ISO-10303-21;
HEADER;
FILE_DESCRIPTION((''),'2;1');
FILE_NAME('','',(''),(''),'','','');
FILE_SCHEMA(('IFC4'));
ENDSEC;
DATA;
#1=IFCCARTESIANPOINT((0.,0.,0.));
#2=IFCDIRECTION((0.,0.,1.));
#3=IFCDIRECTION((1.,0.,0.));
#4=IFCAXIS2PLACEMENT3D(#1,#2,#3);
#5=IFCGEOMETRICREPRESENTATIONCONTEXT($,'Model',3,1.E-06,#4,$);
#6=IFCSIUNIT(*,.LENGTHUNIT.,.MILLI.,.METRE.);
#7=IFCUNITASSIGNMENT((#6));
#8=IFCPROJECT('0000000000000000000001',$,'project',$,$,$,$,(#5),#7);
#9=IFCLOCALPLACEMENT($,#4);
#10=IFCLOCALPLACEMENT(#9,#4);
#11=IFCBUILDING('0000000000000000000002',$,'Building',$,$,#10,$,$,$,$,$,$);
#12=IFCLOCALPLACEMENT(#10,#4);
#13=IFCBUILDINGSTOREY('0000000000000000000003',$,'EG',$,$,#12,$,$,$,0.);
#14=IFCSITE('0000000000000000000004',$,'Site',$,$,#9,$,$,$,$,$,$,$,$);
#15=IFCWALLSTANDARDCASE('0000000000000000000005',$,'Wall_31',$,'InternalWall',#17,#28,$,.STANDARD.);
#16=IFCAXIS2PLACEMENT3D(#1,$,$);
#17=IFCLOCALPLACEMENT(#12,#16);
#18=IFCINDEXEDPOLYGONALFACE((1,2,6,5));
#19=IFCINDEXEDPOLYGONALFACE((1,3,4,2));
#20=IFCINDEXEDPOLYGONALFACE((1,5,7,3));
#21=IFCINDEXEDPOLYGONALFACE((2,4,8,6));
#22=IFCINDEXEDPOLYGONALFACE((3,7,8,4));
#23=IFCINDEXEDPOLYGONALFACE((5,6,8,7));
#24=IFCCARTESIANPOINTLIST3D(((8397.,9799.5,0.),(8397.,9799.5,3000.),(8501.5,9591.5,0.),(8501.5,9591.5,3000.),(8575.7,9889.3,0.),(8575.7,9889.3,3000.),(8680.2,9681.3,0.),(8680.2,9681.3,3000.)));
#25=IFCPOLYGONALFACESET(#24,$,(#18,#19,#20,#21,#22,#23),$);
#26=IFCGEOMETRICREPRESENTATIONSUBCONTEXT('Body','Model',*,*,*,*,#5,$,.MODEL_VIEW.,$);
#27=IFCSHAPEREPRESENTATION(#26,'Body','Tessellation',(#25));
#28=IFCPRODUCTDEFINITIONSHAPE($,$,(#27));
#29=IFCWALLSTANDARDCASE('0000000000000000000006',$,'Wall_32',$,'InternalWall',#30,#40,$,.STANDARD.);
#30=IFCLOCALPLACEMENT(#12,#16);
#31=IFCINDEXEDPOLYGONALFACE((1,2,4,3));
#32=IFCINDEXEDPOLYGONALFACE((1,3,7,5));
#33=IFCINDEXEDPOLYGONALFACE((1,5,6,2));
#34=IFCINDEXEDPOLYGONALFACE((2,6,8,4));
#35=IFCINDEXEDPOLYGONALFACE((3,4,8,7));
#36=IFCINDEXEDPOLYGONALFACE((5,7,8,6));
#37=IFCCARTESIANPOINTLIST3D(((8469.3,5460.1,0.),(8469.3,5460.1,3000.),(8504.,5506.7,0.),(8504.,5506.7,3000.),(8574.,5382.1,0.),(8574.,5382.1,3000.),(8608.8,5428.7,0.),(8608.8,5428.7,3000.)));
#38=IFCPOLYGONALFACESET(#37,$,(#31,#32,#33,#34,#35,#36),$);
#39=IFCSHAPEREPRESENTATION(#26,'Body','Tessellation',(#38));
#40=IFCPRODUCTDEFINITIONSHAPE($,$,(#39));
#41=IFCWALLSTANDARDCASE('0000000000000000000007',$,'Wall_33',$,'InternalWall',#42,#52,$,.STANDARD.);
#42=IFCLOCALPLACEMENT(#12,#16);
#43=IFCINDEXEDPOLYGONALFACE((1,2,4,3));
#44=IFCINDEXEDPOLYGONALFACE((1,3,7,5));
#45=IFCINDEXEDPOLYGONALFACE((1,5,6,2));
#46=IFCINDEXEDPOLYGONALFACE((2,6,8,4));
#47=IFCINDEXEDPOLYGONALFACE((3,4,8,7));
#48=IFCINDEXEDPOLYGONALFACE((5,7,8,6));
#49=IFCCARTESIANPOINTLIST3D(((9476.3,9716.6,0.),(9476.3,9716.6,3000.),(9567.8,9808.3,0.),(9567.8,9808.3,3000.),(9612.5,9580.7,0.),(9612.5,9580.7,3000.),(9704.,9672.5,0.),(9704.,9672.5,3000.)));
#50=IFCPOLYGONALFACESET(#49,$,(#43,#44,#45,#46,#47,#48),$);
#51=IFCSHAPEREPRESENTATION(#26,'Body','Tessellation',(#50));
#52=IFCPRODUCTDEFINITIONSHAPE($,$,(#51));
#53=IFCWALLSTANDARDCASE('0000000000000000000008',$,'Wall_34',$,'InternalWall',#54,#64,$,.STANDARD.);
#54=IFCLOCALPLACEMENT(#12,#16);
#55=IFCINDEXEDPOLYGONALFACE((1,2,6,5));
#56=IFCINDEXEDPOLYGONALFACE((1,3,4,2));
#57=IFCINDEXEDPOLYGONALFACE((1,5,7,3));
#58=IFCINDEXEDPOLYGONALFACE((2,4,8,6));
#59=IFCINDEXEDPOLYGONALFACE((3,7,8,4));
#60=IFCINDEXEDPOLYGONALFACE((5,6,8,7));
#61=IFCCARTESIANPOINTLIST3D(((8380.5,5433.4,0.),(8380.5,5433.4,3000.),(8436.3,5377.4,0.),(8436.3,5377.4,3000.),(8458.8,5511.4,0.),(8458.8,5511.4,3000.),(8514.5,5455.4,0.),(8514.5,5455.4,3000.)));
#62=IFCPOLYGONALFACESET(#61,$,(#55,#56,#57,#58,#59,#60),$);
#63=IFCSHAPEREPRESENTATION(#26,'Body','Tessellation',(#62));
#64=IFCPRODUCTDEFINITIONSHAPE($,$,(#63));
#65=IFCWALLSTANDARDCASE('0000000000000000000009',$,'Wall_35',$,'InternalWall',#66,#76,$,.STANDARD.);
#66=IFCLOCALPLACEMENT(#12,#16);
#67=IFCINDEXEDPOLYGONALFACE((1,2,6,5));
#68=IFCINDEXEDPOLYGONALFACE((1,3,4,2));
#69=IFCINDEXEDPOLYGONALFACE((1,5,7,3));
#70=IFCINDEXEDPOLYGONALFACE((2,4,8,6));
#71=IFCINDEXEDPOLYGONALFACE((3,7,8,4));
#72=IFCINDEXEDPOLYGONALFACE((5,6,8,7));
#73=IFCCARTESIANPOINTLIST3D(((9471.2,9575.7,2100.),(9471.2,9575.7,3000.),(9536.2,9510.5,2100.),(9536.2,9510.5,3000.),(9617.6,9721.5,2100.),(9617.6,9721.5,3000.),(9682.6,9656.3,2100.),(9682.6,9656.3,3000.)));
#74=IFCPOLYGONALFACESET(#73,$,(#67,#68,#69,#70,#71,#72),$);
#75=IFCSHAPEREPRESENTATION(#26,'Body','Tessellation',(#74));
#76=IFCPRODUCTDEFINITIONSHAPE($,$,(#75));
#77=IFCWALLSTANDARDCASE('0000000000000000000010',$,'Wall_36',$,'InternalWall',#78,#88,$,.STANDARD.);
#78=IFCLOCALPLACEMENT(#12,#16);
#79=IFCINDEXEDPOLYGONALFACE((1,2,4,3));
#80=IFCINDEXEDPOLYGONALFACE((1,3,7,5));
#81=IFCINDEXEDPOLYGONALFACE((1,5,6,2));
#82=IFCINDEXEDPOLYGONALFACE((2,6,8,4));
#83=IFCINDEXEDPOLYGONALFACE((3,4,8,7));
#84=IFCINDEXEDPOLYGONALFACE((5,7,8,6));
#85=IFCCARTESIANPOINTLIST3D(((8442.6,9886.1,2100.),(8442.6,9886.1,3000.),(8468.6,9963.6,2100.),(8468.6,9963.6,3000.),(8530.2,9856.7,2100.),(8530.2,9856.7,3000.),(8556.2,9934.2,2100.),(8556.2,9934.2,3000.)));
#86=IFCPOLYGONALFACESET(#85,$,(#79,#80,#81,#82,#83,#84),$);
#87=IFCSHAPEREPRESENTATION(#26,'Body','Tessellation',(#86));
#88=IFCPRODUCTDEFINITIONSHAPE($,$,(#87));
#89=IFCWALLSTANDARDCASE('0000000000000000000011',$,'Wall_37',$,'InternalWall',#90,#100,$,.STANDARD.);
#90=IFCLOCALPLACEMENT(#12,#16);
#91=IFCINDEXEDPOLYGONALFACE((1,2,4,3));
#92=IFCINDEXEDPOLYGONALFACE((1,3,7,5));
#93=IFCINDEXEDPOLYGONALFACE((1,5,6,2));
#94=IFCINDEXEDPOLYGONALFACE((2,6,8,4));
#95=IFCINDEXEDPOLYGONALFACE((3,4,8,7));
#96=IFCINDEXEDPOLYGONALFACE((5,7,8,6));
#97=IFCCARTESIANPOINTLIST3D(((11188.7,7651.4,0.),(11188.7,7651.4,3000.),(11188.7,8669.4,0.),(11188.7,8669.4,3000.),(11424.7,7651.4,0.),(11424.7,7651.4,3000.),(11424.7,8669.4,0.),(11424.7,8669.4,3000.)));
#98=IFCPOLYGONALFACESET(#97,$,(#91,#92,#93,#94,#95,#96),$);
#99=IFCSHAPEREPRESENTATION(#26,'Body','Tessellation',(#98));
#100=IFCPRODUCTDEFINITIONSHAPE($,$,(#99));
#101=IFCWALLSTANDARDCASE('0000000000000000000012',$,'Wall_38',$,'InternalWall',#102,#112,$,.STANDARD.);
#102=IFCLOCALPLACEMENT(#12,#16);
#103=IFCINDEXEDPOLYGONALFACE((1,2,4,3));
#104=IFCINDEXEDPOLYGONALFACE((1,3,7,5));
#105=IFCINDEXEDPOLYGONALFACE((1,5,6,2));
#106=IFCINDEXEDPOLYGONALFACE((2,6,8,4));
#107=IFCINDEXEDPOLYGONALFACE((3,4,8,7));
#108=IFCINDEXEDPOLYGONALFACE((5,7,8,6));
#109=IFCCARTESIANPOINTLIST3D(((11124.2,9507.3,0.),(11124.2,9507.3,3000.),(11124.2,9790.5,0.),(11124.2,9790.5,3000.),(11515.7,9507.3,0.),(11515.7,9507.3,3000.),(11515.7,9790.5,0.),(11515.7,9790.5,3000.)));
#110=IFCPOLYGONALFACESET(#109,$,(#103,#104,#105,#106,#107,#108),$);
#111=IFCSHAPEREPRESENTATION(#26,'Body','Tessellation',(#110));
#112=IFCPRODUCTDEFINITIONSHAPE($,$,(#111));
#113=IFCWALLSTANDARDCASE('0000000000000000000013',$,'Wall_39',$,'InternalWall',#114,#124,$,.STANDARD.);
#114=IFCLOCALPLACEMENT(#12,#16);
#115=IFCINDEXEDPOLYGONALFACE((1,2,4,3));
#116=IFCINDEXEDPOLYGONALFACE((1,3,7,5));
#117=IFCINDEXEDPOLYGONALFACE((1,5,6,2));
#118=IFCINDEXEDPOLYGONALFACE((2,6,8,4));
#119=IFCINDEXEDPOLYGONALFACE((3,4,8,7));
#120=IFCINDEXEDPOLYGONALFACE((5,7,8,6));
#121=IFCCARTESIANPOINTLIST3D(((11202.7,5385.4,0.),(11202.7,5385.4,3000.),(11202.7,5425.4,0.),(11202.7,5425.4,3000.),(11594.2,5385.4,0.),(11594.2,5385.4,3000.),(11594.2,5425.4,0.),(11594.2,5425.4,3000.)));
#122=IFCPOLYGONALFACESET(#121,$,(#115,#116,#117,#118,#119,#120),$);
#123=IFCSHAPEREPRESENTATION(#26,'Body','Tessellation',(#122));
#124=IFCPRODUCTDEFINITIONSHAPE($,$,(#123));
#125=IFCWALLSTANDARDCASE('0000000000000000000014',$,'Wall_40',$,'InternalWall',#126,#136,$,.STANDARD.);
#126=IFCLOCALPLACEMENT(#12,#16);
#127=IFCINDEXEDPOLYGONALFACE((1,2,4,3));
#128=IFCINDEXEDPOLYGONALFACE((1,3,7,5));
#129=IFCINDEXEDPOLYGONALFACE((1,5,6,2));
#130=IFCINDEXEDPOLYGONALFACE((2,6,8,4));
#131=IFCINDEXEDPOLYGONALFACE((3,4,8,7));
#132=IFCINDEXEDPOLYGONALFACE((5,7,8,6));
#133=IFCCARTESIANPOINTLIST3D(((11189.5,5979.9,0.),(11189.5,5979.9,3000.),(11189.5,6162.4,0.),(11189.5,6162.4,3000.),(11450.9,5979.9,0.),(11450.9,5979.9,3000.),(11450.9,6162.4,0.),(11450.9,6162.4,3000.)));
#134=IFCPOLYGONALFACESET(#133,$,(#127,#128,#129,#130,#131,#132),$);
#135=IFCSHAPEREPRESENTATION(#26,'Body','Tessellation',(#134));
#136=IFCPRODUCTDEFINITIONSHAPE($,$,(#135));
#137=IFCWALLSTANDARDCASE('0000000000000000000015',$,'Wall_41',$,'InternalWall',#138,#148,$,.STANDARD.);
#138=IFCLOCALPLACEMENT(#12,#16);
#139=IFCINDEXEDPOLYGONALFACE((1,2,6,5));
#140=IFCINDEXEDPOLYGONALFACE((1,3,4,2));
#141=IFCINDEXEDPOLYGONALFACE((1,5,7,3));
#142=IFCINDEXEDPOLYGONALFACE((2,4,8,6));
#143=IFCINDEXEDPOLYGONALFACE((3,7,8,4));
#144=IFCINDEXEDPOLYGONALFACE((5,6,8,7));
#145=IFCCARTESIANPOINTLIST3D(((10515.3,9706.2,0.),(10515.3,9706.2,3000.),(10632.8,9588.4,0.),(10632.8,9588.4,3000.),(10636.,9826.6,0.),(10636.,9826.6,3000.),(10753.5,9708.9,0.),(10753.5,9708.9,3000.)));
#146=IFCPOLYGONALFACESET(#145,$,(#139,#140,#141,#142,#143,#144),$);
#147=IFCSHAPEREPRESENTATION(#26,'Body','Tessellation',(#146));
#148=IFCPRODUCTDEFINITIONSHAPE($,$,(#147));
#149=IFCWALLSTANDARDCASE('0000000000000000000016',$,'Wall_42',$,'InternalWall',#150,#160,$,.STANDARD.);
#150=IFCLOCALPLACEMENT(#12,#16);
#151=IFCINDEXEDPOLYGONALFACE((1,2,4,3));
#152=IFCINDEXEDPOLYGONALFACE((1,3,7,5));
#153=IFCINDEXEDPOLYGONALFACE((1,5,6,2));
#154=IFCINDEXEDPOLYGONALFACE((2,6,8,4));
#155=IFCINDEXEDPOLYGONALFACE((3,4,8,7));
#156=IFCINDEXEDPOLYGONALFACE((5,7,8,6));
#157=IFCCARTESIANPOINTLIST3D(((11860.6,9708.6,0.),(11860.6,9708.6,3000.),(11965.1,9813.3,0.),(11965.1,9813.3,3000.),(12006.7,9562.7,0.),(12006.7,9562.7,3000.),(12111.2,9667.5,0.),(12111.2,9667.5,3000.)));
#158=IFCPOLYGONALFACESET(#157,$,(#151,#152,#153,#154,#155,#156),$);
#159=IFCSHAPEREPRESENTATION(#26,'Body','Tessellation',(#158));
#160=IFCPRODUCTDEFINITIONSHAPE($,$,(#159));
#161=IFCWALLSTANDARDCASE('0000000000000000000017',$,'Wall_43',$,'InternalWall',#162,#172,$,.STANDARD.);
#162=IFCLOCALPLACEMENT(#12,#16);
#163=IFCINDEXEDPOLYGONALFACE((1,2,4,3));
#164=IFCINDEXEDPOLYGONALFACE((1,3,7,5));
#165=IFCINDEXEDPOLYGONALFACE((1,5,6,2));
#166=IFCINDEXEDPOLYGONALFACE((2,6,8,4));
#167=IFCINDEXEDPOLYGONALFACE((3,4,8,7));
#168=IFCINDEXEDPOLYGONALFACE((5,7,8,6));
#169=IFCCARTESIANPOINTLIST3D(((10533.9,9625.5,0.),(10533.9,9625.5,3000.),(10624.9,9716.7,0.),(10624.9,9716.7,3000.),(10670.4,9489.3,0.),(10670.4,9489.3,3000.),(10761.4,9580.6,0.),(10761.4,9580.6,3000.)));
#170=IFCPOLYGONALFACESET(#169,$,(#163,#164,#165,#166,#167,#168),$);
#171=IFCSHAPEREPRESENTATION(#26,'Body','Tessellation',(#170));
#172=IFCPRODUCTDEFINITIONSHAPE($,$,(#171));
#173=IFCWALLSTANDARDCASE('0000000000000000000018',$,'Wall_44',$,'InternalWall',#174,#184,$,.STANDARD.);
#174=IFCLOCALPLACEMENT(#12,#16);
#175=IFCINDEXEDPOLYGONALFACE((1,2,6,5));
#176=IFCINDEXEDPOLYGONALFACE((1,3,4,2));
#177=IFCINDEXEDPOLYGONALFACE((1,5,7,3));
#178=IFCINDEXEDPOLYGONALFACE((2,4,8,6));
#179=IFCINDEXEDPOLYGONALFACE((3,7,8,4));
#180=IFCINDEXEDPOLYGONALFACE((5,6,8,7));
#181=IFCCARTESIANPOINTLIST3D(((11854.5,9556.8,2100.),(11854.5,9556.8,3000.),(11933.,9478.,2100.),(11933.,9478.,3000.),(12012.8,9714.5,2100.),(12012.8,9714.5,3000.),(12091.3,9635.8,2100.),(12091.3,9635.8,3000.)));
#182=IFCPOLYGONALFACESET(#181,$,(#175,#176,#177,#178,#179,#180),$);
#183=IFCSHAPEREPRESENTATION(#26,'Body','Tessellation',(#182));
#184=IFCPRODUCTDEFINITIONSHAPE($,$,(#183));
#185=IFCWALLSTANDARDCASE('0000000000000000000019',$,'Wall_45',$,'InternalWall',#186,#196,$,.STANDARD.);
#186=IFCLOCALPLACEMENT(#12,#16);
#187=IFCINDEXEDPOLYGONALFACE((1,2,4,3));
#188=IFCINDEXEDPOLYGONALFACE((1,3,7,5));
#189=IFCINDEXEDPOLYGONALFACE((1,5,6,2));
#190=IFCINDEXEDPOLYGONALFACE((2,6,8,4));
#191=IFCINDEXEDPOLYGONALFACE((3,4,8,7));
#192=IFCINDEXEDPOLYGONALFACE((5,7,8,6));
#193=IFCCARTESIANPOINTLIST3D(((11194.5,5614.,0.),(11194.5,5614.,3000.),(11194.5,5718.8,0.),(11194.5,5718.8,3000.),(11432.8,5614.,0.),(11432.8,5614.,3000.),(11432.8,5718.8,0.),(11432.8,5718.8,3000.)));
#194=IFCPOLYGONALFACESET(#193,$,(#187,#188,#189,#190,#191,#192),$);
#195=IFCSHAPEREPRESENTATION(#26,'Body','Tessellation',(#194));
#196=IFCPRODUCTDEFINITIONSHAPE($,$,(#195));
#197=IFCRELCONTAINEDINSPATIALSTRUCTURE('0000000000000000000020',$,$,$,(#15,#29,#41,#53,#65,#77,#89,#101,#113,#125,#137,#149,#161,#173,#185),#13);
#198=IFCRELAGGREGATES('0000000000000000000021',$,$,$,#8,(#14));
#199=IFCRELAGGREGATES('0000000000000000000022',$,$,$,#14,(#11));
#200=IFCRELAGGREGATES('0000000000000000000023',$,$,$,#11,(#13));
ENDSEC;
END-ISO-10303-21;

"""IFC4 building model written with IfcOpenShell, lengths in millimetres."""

from ifc_helpers import new_model, si_unit, frame, origin_with_axes, place, context, subcontext, project, spatial, rectangle, extrude, element, save


model = new_model("IFC4")

# Units and contexts
model_context = context("Model", 3, precision=1e-06, world=origin_with_axes())
body_context = subcontext(model_context, "Body", "Model", "MODEL_VIEW")
ifc_project = project(units=[si_unit("LENGTHUNIT", "METRE", prefix="MILLI")], contexts=[model_context])

# Site, building, storey
site_placement = place(None, origin_with_axes())
site = spatial("IfcSite", under=ifc_project, at=site_placement, Name="Site")
building_placement = place(site_placement, origin_with_axes())
building = spatial("IfcBuilding", under=site, at=building_placement, Name="Building")
storey_placement = place(building_placement, origin_with_axes())
storey = spatial("IfcBuildingStorey", under=building, at=storey_placement, Name="EG", Elevation=0.0)

# Walls
wall_1_placement = place(storey_placement, origin_with_axes())
element("IfcWallStandardCase", 1, at=wall_1_placement, inside=storey, Name="Wall_31", ObjectType="InternalWall", PredefinedType="STANDARD", context=body_context, shape_type="SweptSolid", body=[
    extrude(rectangle(XDim=232.8, YDim=200.0), frame((8538.6, 9740.4, 0.0), z_axis=(0.0, 0.0, 1.0), x_axis=(-0.448931, 0.893566, 0.0)), (0.0, 0.0, 1.0), 3000.0),
])
wall_2_placement = place(storey_placement, origin_with_axes())
element("IfcWallStandardCase", 2, at=wall_2_placement, inside=storey, Name="Wall_32", ObjectType="InternalWall", PredefinedType="STANDARD", context=body_context, shape_type="SweptSolid", body=[
    extrude(rectangle(XDim=130.6, YDim=58.2), frame((8539.0, 5444.4, 0.0), z_axis=(0.0, 0.0, 1.0), x_axis=(0.802063, -0.59724, 0.0)), (0.0, 0.0, 1.0), 3000.0),
])
wall_3_placement = place(storey_placement, origin_with_axes())
element("IfcWallStandardCase", 3, at=wall_3_placement, inside=storey, Name="Wall_33", ObjectType="InternalWall", PredefinedType="STANDARD", context=body_context, shape_type="SweptSolid", body=[
    extrude(rectangle(XDim=129.6, YDim=192.4), frame((9590.1, 9694.5, 0.0), z_axis=(0.0, 0.0, 1.0), x_axis=(0.706141, 0.708071, 0.0)), (0.0, 0.0, 1.0), 3000.0),
])
wall_4_placement = place(storey_placement, origin_with_axes())
element("IfcWallStandardCase", 4, at=wall_4_placement, inside=storey, Name="Wall_34", ObjectType="InternalWall", PredefinedType="STANDARD", context=body_context, shape_type="SweptSolid", body=[
    extrude(rectangle(XDim=110.5, YDim=79.0), frame((8447.5, 5444.4, 0.0), z_axis=(0.0, 0.0, 1.0), x_axis=(-0.708237, -0.705975, 0.0)), (0.0, 0.0, 1.0), 3000.0),
])

# Walls, openings
wall_5_placement = place(storey_placement, origin_with_axes())
wall_5 = element("IfcWallStandardCase", 5, at=wall_5_placement, inside=storey, Name="Wall_35", ObjectType="InternalWall", PredefinedType="STANDARD", context=body_context, shape_type="SweptSolid", body=[
    extrude(rectangle(XDim=92.1, YDim=206.6), frame((9576.9, 9616.0, 0.0), z_axis=(0.0, 0.0, 1.0), x_axis=(0.705748, -0.708463, 0.0)), (0.0, 0.0, 1.0), 3000.0),
])
opening_1_placement = place(wall_5_placement, origin_with_axes())
element("IfcOpeningElement", 6, at=opening_1_placement, inside=storey, cuts=wall_5, context=body_context, shape_type="SweptSolid", body=[
    extrude(rectangle(XDim=450.0, YDim=206.6), frame((9576.9, 9616.0, 0.0), z_axis=(0.0, 0.0, 1.0), x_axis=(0.705748, -0.708463, 0.0)), (0.0, 0.0, 1.0), 2100.0),
])
wall_6_placement = place(storey_placement, origin_with_axes())
wall_6 = element("IfcWallStandardCase", 7, at=wall_6_placement, inside=storey, Name="Wall_36", ObjectType="InternalWall", PredefinedType="STANDARD", context=body_context, shape_type="SweptSolid", body=[
    extrude(rectangle(XDim=81.7, YDim=92.5), frame((8499.4, 9910.1, 0.0), z_axis=(0.0, 0.0, 1.0), x_axis=(0.318062, 0.94807, 0.0)), (0.0, 0.0, 1.0), 3000.0),
])
opening_2_placement = place(wall_6_placement, origin_with_axes())
element("IfcOpeningElement", 8, at=opening_2_placement, inside=storey, cuts=wall_6, context=body_context, shape_type="SweptSolid", body=[
    extrude(rectangle(XDim=450.0, YDim=92.5), frame((8499.4, 9910.1, 0.0), z_axis=(0.0, 0.0, 1.0), x_axis=(0.318062, 0.94807, 0.0)), (0.0, 0.0, 1.0), 2100.0),
])

# Walls
wall_7_placement = place(storey_placement, origin_with_axes())
element("IfcWallStandardCase", 9, at=wall_7_placement, inside=storey, Name="Wall_37", ObjectType="InternalWall", PredefinedType="STANDARD", context=body_context, shape_type="SweptSolid", body=[
    extrude(rectangle(XDim=1018.0, YDim=236.0), frame((11306.7, 8160.4, 0.0), z_axis=(0.0, 0.0, 1.0), x_axis=(0.0, 1.0, 0.0)), (0.0, 0.0, 1.0), 3000.0),
])
wall_8_placement = place(storey_placement, origin_with_axes())
element("IfcWallStandardCase", 10, at=wall_8_placement, inside=storey, Name="Wall_38", ObjectType="InternalWall", PredefinedType="STANDARD", context=body_context, shape_type="SweptSolid", body=[
    extrude(rectangle(XDim=391.5, YDim=283.2), frame((11319.9, 9648.9, 0.0), z_axis=(0.0, 0.0, 1.0), x_axis=(1.0, 0.0, 0.0)), (0.0, 0.0, 1.0), 3000.0),
])
wall_9_placement = place(storey_placement, origin_with_axes())
element("IfcWallStandardCase", 11, at=wall_9_placement, inside=storey, Name="Wall_39", ObjectType="InternalWall", PredefinedType="STANDARD", context=body_context, shape_type="SweptSolid", body=[
    extrude(rectangle(XDim=391.5, YDim=40.0), frame((11398.4, 5405.4, 0.0), z_axis=(0.0, 0.0, 1.0), x_axis=(-1.0, 0.0, 0.0)), (0.0, 0.0, 1.0), 3000.0),
])
wall_10_placement = place(storey_placement, origin_with_axes())
element("IfcWallStandardCase", 12, at=wall_10_placement, inside=storey, Name="Wall_40", ObjectType="InternalWall", PredefinedType="STANDARD", context=body_context, shape_type="SweptSolid", body=[
    extrude(rectangle(XDim=182.5, YDim=261.4), frame((11320.2, 6071.1, 0.0), z_axis=(0.0, 0.0, 1.0), x_axis=(0.0, 1.0, 0.0)), (0.0, 0.0, 1.0), 3000.0),
])
wall_11_placement = place(storey_placement, origin_with_axes())
element("IfcWallStandardCase", 13, at=wall_11_placement, inside=storey, Name="Wall_41", ObjectType="InternalWall", PredefinedType="STANDARD", context=body_context, shape_type="SweptSolid", body=[
    extrude(rectangle(XDim=166.3, YDim=170.5), frame((10634.4, 9707.5, 0.0), z_axis=(0.0, 0.0, 1.0), x_axis=(-0.706355, 0.707858, 0.0)), (0.0, 0.0, 1.0), 3000.0),
])
wall_12_placement = place(storey_placement, origin_with_axes())
element("IfcWallStandardCase", 14, at=wall_12_placement, inside=storey, Name="Wall_42", ObjectType="InternalWall", PredefinedType="STANDARD", context=body_context, shape_type="SweptSolid", body=[
    extrude(rectangle(XDim=148.0, YDim=206.5), frame((11985.9, 9688.0, 0.0), z_axis=(0.0, 0.0, 1.0), x_axis=(0.706261, 0.707951, 0.0)), (0.0, 0.0, 1.0), 3000.0),
])
wall_13_placement = place(storey_placement, origin_with_axes())
element("IfcWallStandardCase", 15, at=wall_13_placement, inside=storey, Name="Wall_43", ObjectType="InternalWall", PredefinedType="STANDARD", context=body_context, shape_type="SweptSolid", body=[
    extrude(rectangle(XDim=128.9, YDim=192.8), frame((10647.7, 9603.0, 0.0), z_axis=(0.0, 0.0, 1.0), x_axis=(-0.706136, -0.708076, 0.0)), (0.0, 0.0, 1.0), 3000.0),
])

# Wall, opening
wall_14_placement = place(storey_placement, origin_with_axes())
wall_14 = element("IfcWallStandardCase", 16, at=wall_14_placement, inside=storey, Name="Wall_44", ObjectType="InternalWall", PredefinedType="STANDARD", context=body_context, shape_type="SweptSolid", body=[
    extrude(rectangle(XDim=111.2, YDim=223.4), frame((11972.9, 9596.3, 0.0), z_axis=(0.0, 0.0, 1.0), x_axis=(0.705982, -0.70823, 0.0)), (0.0, 0.0, 1.0), 3000.0),
])
opening_3_placement = place(wall_14_placement, origin_with_axes())
element("IfcOpeningElement", 17, at=opening_3_placement, inside=storey, cuts=wall_14, context=body_context, shape_type="SweptSolid", body=[
    extrude(rectangle(XDim=450.0, YDim=223.4), frame((11979.3, 9589.9, 0.0), z_axis=(0.0, 0.0, 1.0), x_axis=(0.705982, -0.70823, 0.0)), (0.0, 0.0, 1.0), 2100.0),
])

# Wall
wall_15_placement = place(storey_placement, origin_with_axes())
element("IfcWallStandardCase", 18, at=wall_15_placement, inside=storey, Name="Wall_45", ObjectType="InternalWall", PredefinedType="STANDARD", context=body_context, shape_type="SweptSolid", body=[
    extrude(rectangle(XDim=104.8, YDim=238.3), frame((11313.7, 5666.4, 0.0), z_axis=(0.0, 0.0, 1.0), x_axis=(0.0, -1.0, 0.0)), (0.0, 0.0, 1.0), 3000.0),
])

save(model, "model.ifc")
